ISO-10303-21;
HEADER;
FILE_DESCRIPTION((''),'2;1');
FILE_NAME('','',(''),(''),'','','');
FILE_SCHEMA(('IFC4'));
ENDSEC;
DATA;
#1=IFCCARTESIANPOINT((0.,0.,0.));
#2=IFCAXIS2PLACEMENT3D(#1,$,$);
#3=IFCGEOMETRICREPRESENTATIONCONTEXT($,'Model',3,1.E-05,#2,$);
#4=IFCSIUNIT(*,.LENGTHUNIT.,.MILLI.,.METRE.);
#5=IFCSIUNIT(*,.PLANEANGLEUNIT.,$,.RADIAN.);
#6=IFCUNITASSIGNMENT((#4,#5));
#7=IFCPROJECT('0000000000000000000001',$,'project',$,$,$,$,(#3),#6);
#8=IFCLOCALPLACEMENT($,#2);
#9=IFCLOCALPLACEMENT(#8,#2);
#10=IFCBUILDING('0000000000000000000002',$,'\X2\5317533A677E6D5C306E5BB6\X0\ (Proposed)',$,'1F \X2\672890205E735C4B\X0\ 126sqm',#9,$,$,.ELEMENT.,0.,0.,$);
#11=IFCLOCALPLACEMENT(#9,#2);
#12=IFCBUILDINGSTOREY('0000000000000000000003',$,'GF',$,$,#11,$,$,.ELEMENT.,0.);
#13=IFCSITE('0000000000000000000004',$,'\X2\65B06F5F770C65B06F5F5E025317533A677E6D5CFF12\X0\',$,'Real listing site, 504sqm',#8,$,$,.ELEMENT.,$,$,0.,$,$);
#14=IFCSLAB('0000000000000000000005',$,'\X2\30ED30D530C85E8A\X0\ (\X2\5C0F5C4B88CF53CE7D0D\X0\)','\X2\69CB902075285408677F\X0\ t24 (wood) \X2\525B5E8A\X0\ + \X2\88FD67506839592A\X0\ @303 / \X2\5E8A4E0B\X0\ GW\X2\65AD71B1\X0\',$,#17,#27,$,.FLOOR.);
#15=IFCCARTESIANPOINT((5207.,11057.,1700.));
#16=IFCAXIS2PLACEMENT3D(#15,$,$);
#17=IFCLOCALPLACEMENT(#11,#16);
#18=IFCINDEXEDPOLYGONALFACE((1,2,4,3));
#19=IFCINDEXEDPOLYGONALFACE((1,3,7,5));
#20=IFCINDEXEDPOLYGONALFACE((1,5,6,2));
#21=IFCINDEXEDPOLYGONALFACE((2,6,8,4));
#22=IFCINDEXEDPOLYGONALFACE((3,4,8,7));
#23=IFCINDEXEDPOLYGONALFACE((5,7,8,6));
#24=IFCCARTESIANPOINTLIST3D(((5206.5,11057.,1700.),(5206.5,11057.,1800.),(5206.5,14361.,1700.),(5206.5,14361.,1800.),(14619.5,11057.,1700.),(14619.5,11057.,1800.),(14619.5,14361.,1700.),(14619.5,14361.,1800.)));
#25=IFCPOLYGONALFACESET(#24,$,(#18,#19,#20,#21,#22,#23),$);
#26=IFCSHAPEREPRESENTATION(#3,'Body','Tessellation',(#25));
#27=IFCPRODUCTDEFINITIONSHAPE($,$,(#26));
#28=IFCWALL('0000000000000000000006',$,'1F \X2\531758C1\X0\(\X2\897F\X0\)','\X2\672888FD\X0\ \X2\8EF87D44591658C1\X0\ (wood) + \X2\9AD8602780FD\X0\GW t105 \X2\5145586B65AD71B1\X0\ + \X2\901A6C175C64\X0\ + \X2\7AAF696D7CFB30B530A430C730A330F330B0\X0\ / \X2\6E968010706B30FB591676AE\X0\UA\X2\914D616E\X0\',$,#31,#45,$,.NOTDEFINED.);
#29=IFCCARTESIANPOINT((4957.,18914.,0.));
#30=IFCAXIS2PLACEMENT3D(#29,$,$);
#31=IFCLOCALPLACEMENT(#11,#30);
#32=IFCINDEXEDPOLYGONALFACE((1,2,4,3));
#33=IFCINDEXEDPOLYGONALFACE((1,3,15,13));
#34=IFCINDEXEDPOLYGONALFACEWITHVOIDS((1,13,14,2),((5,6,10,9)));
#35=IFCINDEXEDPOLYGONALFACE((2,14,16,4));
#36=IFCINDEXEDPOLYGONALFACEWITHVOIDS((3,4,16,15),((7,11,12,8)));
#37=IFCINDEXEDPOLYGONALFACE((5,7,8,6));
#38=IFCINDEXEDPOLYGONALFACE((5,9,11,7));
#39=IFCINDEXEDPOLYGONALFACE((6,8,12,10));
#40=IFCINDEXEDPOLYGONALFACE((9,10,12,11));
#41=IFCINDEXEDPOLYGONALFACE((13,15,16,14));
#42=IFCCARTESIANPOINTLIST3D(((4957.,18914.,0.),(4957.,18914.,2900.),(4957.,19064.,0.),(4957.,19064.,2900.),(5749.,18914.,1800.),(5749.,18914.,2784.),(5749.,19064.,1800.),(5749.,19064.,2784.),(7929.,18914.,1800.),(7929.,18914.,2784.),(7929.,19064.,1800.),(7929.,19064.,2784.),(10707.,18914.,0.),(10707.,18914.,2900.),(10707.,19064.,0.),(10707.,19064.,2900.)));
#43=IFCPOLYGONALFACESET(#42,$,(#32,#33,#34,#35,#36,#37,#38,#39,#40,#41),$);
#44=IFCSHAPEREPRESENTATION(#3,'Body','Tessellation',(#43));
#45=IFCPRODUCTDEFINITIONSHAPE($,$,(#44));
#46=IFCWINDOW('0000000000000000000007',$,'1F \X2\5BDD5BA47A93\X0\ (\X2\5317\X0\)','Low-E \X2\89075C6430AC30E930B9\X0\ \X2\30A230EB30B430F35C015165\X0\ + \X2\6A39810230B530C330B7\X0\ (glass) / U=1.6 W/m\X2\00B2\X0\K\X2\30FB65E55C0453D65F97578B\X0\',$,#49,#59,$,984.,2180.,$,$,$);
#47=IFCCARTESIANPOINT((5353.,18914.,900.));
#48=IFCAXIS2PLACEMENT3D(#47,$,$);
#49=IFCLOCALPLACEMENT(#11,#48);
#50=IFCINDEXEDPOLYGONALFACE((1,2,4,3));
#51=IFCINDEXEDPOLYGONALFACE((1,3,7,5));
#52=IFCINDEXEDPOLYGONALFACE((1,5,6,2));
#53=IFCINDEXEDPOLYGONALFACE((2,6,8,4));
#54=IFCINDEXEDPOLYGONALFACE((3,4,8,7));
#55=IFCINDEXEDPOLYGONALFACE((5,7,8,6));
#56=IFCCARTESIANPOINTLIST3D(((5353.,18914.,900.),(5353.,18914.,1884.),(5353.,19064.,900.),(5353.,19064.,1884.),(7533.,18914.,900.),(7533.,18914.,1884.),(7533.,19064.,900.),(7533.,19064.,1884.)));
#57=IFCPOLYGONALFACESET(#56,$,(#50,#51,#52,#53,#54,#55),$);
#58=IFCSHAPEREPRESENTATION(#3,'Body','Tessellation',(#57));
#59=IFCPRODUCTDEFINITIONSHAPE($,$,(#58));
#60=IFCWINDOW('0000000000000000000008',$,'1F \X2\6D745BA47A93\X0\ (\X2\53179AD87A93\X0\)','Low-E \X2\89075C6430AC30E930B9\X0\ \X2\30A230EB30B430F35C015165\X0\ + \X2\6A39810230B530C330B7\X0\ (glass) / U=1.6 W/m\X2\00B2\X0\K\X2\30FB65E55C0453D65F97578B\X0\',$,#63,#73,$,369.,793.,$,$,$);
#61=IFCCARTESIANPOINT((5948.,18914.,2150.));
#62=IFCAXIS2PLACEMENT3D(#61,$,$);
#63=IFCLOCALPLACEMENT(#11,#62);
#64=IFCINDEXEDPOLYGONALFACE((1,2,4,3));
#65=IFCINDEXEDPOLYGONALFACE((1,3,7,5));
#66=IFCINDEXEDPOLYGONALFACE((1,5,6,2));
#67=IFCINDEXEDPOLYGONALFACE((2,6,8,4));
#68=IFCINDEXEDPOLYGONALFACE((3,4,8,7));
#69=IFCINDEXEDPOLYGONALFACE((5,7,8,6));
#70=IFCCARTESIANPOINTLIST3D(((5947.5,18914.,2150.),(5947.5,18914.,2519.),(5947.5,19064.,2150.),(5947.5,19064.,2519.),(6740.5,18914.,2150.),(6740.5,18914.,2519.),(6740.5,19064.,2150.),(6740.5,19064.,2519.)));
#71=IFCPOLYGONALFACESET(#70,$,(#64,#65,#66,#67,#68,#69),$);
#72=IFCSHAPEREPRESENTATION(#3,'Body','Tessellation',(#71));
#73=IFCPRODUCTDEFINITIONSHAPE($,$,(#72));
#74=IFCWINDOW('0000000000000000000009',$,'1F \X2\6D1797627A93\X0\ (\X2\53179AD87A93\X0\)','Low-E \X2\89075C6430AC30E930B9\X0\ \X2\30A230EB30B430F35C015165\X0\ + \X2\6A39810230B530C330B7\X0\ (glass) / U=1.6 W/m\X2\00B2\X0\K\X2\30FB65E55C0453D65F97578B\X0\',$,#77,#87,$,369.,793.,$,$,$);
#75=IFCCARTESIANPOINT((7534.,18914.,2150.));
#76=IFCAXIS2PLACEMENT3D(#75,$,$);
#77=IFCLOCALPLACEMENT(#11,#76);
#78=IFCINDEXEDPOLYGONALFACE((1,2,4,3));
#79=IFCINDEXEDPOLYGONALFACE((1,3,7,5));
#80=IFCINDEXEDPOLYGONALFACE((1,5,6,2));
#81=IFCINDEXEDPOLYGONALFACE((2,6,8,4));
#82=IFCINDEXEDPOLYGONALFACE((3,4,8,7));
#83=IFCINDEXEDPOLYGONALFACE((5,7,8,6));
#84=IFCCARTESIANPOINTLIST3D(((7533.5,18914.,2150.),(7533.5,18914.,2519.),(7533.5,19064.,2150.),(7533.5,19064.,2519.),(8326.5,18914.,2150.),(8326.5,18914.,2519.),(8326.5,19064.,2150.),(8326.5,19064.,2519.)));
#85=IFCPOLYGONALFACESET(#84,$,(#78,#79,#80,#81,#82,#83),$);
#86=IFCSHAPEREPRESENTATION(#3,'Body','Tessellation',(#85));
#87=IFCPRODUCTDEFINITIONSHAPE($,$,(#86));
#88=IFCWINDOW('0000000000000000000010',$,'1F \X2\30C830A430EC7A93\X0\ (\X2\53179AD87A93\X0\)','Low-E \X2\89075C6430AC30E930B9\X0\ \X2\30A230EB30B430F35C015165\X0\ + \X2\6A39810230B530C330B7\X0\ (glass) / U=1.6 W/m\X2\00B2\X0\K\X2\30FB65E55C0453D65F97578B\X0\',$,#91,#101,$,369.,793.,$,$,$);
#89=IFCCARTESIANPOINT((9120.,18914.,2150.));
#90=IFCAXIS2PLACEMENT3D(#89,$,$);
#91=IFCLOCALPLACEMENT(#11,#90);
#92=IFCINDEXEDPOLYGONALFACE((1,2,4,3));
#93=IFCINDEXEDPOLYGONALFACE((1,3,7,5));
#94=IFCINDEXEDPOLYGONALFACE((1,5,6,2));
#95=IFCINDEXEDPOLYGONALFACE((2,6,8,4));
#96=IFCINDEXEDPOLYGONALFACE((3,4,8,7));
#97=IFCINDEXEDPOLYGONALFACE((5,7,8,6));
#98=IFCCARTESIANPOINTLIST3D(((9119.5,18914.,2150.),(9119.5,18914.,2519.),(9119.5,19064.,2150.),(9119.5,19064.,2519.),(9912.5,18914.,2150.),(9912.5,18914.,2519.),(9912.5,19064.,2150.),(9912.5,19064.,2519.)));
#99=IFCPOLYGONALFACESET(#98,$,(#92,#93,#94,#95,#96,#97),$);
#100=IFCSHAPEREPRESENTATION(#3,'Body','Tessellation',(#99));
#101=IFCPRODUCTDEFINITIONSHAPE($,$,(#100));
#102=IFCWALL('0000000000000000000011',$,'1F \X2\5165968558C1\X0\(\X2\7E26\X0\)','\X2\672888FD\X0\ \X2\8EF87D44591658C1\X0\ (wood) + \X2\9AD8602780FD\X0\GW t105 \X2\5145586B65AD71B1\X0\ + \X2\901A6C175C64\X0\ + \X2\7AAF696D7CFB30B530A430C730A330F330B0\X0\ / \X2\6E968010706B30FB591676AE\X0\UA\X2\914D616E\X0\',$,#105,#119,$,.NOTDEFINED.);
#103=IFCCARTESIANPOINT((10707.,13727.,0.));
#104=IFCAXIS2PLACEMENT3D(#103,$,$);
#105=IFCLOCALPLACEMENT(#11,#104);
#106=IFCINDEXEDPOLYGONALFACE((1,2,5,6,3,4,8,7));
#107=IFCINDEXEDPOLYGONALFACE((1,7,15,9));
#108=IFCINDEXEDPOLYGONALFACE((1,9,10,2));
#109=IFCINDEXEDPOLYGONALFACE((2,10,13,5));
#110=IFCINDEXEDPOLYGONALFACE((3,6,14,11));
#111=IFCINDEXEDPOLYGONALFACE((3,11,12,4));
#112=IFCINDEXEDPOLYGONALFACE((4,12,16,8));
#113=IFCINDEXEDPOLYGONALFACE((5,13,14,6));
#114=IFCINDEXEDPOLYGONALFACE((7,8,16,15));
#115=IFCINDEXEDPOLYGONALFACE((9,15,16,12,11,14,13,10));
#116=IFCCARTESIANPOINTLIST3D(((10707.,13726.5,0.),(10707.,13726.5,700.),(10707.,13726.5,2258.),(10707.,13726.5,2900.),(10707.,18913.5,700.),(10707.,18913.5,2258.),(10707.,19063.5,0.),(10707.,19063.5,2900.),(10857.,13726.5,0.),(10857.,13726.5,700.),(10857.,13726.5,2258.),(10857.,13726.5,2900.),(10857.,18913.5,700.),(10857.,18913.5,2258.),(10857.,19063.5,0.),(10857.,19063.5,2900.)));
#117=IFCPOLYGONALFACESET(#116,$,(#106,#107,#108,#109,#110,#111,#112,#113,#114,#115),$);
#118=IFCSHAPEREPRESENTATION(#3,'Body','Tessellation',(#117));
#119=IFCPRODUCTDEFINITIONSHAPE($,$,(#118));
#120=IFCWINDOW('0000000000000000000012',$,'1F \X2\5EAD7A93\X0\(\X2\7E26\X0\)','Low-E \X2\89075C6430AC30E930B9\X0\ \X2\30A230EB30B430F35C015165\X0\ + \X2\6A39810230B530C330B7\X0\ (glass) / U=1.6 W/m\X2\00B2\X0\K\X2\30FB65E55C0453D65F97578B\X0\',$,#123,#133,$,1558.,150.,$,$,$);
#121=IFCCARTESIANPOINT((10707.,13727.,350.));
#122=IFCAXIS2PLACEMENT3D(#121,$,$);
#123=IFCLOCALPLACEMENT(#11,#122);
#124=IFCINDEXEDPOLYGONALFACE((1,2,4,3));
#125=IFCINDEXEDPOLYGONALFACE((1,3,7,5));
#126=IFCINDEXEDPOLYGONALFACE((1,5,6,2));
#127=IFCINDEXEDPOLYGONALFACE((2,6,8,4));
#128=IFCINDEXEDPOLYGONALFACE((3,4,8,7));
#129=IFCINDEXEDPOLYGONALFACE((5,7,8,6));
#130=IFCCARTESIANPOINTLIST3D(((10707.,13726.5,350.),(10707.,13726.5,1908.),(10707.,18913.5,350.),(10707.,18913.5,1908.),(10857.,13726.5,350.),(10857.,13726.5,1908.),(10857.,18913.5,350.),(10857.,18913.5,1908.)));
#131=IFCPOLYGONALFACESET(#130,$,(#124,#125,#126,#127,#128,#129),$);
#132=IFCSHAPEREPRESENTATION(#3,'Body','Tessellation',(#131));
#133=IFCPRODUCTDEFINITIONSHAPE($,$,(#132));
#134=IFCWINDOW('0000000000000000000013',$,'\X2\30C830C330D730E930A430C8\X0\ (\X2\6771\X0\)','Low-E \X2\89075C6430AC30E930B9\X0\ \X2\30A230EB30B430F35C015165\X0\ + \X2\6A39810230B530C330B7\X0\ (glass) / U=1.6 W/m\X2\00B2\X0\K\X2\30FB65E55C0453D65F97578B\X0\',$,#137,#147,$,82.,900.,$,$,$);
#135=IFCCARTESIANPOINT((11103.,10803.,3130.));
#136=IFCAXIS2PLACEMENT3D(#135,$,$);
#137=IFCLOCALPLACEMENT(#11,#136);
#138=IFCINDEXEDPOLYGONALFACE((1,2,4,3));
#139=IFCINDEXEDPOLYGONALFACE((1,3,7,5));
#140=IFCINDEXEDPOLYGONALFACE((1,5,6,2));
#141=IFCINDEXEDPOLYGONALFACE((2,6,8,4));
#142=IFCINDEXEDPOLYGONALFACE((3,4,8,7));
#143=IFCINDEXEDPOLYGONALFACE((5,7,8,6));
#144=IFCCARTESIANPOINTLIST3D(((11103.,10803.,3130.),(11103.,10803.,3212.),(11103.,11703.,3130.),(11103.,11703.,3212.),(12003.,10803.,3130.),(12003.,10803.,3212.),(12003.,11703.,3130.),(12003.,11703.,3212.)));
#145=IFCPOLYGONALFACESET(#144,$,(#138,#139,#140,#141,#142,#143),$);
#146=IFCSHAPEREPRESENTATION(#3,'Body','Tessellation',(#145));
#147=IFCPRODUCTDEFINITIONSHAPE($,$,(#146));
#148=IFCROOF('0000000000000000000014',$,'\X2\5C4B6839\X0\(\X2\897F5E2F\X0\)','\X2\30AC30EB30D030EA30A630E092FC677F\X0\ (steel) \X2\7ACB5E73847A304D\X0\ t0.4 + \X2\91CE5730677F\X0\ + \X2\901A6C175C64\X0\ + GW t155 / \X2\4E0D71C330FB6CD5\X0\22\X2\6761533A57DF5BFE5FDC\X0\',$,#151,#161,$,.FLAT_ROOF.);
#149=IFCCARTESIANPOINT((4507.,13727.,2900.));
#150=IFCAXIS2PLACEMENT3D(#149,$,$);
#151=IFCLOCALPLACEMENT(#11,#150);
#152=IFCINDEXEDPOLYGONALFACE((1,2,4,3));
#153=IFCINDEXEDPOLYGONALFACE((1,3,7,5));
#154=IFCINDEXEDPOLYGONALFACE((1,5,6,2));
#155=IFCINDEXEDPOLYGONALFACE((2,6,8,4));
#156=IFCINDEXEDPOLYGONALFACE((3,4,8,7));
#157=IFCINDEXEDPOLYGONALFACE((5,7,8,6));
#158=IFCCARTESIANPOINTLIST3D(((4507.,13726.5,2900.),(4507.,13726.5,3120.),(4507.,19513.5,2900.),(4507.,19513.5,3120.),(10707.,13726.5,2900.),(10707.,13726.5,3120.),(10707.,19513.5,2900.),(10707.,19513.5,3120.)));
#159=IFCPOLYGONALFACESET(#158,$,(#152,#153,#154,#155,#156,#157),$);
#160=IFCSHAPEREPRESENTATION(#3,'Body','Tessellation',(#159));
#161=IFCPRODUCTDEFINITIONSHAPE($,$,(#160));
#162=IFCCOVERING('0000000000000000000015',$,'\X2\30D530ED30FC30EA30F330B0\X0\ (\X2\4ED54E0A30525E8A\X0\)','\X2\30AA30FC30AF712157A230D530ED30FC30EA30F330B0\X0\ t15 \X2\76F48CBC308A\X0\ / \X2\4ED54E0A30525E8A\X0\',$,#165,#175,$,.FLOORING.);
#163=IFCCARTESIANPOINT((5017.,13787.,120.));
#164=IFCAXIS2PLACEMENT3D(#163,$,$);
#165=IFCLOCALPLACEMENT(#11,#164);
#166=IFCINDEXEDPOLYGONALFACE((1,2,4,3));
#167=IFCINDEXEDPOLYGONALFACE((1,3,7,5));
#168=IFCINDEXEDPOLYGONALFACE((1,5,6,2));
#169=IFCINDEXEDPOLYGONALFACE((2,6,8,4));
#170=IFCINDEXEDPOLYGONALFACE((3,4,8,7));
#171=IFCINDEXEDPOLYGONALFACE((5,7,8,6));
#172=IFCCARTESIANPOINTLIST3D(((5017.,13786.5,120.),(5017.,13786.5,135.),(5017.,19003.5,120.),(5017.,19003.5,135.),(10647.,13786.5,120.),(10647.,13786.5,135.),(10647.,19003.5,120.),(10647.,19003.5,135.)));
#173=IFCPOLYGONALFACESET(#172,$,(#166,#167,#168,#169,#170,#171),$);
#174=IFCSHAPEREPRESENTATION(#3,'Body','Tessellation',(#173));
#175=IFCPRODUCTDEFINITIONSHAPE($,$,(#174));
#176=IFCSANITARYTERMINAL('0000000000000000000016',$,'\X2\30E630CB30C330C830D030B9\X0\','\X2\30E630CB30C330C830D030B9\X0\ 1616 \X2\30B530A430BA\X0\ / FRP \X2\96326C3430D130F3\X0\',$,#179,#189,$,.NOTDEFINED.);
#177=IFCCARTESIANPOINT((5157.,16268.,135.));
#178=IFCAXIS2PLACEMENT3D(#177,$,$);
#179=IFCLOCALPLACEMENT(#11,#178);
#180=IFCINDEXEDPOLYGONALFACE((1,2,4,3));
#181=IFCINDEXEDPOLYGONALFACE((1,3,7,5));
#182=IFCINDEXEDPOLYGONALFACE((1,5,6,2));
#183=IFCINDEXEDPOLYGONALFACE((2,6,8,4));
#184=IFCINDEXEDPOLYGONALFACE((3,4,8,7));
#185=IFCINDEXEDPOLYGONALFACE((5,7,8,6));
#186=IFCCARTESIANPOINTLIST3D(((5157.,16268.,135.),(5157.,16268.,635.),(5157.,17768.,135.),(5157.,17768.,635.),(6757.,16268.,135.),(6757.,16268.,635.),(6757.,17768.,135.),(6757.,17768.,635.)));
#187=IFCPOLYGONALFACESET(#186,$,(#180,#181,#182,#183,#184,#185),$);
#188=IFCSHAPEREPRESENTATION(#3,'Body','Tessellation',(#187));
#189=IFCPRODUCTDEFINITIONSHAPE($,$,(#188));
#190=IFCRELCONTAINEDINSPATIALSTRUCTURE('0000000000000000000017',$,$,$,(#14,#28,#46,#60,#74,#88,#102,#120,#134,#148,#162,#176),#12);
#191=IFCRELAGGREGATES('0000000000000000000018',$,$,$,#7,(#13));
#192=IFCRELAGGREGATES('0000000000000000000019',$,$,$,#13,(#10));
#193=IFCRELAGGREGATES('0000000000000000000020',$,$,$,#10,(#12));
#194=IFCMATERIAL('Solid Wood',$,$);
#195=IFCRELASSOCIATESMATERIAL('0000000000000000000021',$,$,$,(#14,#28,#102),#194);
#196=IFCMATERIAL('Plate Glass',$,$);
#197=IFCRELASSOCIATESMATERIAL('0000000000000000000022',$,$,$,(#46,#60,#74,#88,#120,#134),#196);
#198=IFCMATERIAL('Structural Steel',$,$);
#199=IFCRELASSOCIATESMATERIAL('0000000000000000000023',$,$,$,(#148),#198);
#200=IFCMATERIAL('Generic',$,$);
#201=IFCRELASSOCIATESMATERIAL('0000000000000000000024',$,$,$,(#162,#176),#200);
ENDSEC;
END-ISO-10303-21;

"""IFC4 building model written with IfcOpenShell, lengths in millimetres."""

from ifc_helpers import new_model, si_unit, frame, frame_2d, origin, place, context, project, spatial, rectangle, extrude, material, element, fill, save


model = new_model("IFC4")

# Units and contexts
model_context = context("Model", 3, precision=1e-05, world=origin())
ifc_project = project(units=[si_unit("LENGTHUNIT", "METRE", prefix="MILLI"), si_unit("PLANEANGLEUNIT", "RADIAN")], contexts=[model_context])

# Site, building, storey
site_placement = place(None, origin())
site = spatial("IfcSite", under=ifc_project, at=site_placement, Name="新潟県新潟市北区松浜２", ObjectType="Real listing site, 504sqm", CompositionType="ELEMENT", RefElevation=0.0)
building_placement = place(site_placement, origin())
building = spatial("IfcBuilding", under=site, at=building_placement, Name="北区松浜の家 (Proposed)", ObjectType="1F 木造平屋 126sqm", CompositionType="ELEMENT", ElevationOfRefHeight=0.0, ElevationOfTerrain=0.0)
storey_placement = place(building_placement, origin())
storey = spatial("IfcBuildingStorey", under=building, at=storey_placement, Name="GF", CompositionType="ELEMENT", Elevation=0.0)

# Slab
ifc_material_1 = material(Name="Solid Wood")
slab_1_placement = place(storey_placement, frame((5207.0, 11057.0, 1700.0)))
element("IfcSlab", 1, at=slab_1_placement, inside=storey, material=ifc_material_1, Name="ロフト床 (小屋裏収納)", Description="構造用合板 t24 (wood) 剛床 + 製材根太 @303 / 床下 GW断熱", PredefinedType="FLOOR", context=model_context, shape_type="SweptSolid", body=[
    extrude(rectangle(XDim=9413.0, YDim=3304.0, at=frame_2d((4706.0, 1652.0))), frame((5207.0, 11057.0, 1700.0)), (0.0, 0.0, 1.0), 100.0),
])

# Wall, openings, windows
wall_1_placement = place(storey_placement, frame((4957.0, 18914.0, 0.0)))
wall_1 = element("IfcWall", 2, at=wall_1_placement, inside=storey, material=ifc_material_1, Name="1F 北壁(西)", Description="木製 軸組外壁 (wood) + 高性能GW t105 充填断熱 + 通気層 + 窯業系サイディング / 準耐火・外皮UA配慮", PredefinedType="NOTDEFINED", context=model_context, shape_type="SweptSolid", body=[
    extrude(rectangle(XDim=5750.0, YDim=150.0, at=frame_2d((2875.0, 75.0))), frame((4957.0, 18914.0, 0.0)), (0.0, 0.0, 1.0), 2900.0),
])
opening_1_placement = place(storey_placement, frame((5353.0, 18914.0, 900.0)))
opening_1 = element("IfcOpeningElement", 3, at=opening_1_placement, cuts=wall_1, PredefinedType="NOTDEFINED", context=model_context, shape_type="SweptSolid", body=[
    extrude(rectangle(XDim=2180.0, YDim=150.0, at=frame_2d((1090.0, 75.0))), frame((5353.0, 18914.0, 900.0)), (0.0, 0.0, 1.0), 984.0),
])
opening_2_placement = place(storey_placement, frame((5948.0, 18914.0, 2150.0)))
opening_2 = element("IfcOpeningElement", 4, at=opening_2_placement, cuts=wall_1, PredefinedType="NOTDEFINED", context=model_context, shape_type="SweptSolid", body=[
    extrude(rectangle(XDim=793.0, YDim=150.0, at=frame_2d((396.0, 75.0))), frame((5948.0, 18914.0, 2150.0)), (0.0, 0.0, 1.0), 369.0),
])
opening_3_placement = place(storey_placement, frame((7534.0, 18914.0, 2150.0)))
opening_3 = element("IfcOpeningElement", 5, at=opening_3_placement, cuts=wall_1, PredefinedType="NOTDEFINED", context=model_context, shape_type="SweptSolid", body=[
    extrude(rectangle(XDim=793.0, YDim=150.0, at=frame_2d((396.0, 75.0))), frame((7534.0, 18914.0, 2150.0)), (0.0, 0.0, 1.0), 369.0),
])
opening_4_placement = place(storey_placement, frame((9120.0, 18914.0, 2150.0)))
opening_4 = element("IfcOpeningElement", 6, at=opening_4_placement, cuts=wall_1, PredefinedType="NOTDEFINED", context=model_context, shape_type="SweptSolid", body=[
    extrude(rectangle(XDim=793.0, YDim=150.0, at=frame_2d((396.0, 75.0))), frame((9120.0, 18914.0, 2150.0)), (0.0, 0.0, 1.0), 369.0),
])
ifc_material_2 = material(Name="Plate Glass")
window_1_placement = place(storey_placement, frame((5353.0, 18914.0, 900.0)))
window_1 = element("IfcWindow", 7, at=window_1_placement, inside=storey, material=ifc_material_2, Name="1F 寝室窓 (北)", Description="Low-E 複層ガラス アルゴン封入 + 樹脂サッシ (glass) / U=1.6 W/m²K・日射取得型", OverallHeight=984.0, OverallWidth=2180.0, context=model_context, shape_type="SweptSolid", body=[
    extrude(rectangle(XDim=2180.0, YDim=150.0, at=frame_2d((1090.0, 75.0))), frame((5353.0, 18914.0, 900.0)), (0.0, 0.0, 1.0), 984.0),
])
fill(opening_1, window_1)
window_2_placement = place(storey_placement, frame((5948.0, 18914.0, 2150.0)))
window_2 = element("IfcWindow", 8, at=window_2_placement, inside=storey, material=ifc_material_2, Name="1F 浴室窓 (北高窓)", Description="Low-E 複層ガラス アルゴン封入 + 樹脂サッシ (glass) / U=1.6 W/m²K・日射取得型", OverallHeight=369.0, OverallWidth=793.0, context=model_context, shape_type="SweptSolid", body=[
    extrude(rectangle(XDim=793.0, YDim=150.0, at=frame_2d((396.0, 75.0))), frame((5948.0, 18914.0, 2150.0)), (0.0, 0.0, 1.0), 369.0),
])
fill(opening_2, window_2)
window_3_placement = place(storey_placement, frame((7534.0, 18914.0, 2150.0)))
window_3 = element("IfcWindow", 9, at=window_3_placement, inside=storey, material=ifc_material_2, Name="1F 洗面窓 (北高窓)", Description="Low-E 複層ガラス アルゴン封入 + 樹脂サッシ (glass) / U=1.6 W/m²K・日射取得型", OverallHeight=369.0, OverallWidth=793.0, context=model_context, shape_type="SweptSolid", body=[
    extrude(rectangle(XDim=793.0, YDim=150.0, at=frame_2d((396.0, 75.0))), frame((7534.0, 18914.0, 2150.0)), (0.0, 0.0, 1.0), 369.0),
])
fill(opening_3, window_3)
window_4_placement = place(storey_placement, frame((9120.0, 18914.0, 2150.0)))
window_4 = element("IfcWindow", 10, at=window_4_placement, inside=storey, material=ifc_material_2, Name="1F トイレ窓 (北高窓)", Description="Low-E 複層ガラス アルゴン封入 + 樹脂サッシ (glass) / U=1.6 W/m²K・日射取得型", OverallHeight=369.0, OverallWidth=793.0, context=model_context, shape_type="SweptSolid", body=[
    extrude(rectangle(XDim=793.0, YDim=150.0, at=frame_2d((396.0, 75.0))), frame((9120.0, 18914.0, 2150.0)), (0.0, 0.0, 1.0), 369.0),
])
fill(opening_4, window_4)

# Wall, opening, window
wall_2_placement = place(storey_placement, frame((10707.0, 13727.0, 0.0)))
wall_2 = element("IfcWall", 11, at=wall_2_placement, inside=storey, material=ifc_material_1, Name="1F 入隅壁(縦)", Description="木製 軸組外壁 (wood) + 高性能GW t105 充填断熱 + 通気層 + 窯業系サイディング / 準耐火・外皮UA配慮", PredefinedType="NOTDEFINED", context=model_context, shape_type="SweptSolid", body=[
    extrude(rectangle(XDim=150.0, YDim=5337.0, at=frame_2d((75.0, 2668.0))), frame((10707.0, 13727.0, 0.0)), (0.0, 0.0, 1.0), 2900.0),
])
opening_5_placement = place(storey_placement, frame((10707.0, 13727.0, 350.0)))
opening_5 = element("IfcOpeningElement", 12, at=opening_5_placement, cuts=wall_2, PredefinedType="NOTDEFINED", context=model_context, shape_type="SweptSolid", body=[
    extrude(rectangle(XDim=150.0, YDim=5187.0, at=frame_2d((75.0, 2593.0))), frame((10707.0, 13727.0, 350.0)), (0.0, 0.0, 1.0), 1558.0),
])
window_5_placement = place(storey_placement, frame((10707.0, 13727.0, 350.0)))
window_5 = element("IfcWindow", 13, at=window_5_placement, inside=storey, material=ifc_material_2, Name="1F 庭窓(縦)", Description="Low-E 複層ガラス アルゴン封入 + 樹脂サッシ (glass) / U=1.6 W/m²K・日射取得型", OverallHeight=1558.0, OverallWidth=150.0, context=model_context, shape_type="SweptSolid", body=[
    extrude(rectangle(XDim=150.0, YDim=5187.0, at=frame_2d((75.0, 2593.0))), frame((10707.0, 13727.0, 350.0)), (0.0, 0.0, 1.0), 1558.0),
])
fill(opening_5, window_5)

# Window
window_6_placement = place(storey_placement, frame((11103.0, 10803.0, 3130.0)))
element("IfcWindow", 14, at=window_6_placement, inside=storey, material=ifc_material_2, Name="トップライト (東)", Description="Low-E 複層ガラス アルゴン封入 + 樹脂サッシ (glass) / U=1.6 W/m²K・日射取得型", OverallHeight=82.0, OverallWidth=900.0, context=model_context, shape_type="SweptSolid", body=[
    extrude(rectangle(XDim=900.0, YDim=900.0, at=frame_2d((450.0, 450.0))), frame((11103.0, 10803.0, 3130.0)), (0.0, 0.0, 1.0), 82.0),
])

# Roof
ifc_material_3 = material(Name="Structural Steel")
roof_placement = place(storey_placement, frame((4507.0, 13727.0, 2900.0)))
element("IfcRoof", 15, at=roof_placement, inside=storey, material=ifc_material_3, Name="屋根(西帯)", Description="ガルバリウム鋼板 (steel) 立平葺き t0.4 + 野地板 + 通気層 + GW t155 / 不燃・法22条区域対応", PredefinedType="FLAT_ROOF", context=model_context, shape_type="SweptSolid", body=[
    extrude(rectangle(XDim=6200.0, YDim=5787.0, at=frame_2d((3100.0, 2893.0))), frame((4507.0, 13727.0, 2900.0)), (0.0, 0.0, 1.0), 220.0),
])

# Covering
ifc_material_4 = material(Name="Generic")
covering_placement = place(storey_placement, frame((5017.0, 13787.0, 120.0)))
element("IfcCovering", 16, at=covering_placement, inside=storey, material=ifc_material_4, Name="フローリング (仕上げ床)", Description="オーク無垢フローリング t15 直貼り / 仕上げ床", PredefinedType="FLOORING", context=model_context, shape_type="SweptSolid", body=[
    extrude(rectangle(XDim=5630.0, YDim=5217.0, at=frame_2d((2815.0, 2608.0))), frame((5017.0, 13787.0, 120.0)), (0.0, 0.0, 1.0), 15.0),
])

# Sanitary terminal
sanitary_terminal_1_placement = place(storey_placement, frame((5157.0, 16268.0, 135.0)))
element("IfcSanitaryTerminal", 17, at=sanitary_terminal_1_placement, inside=storey, material=ifc_material_4, Name="ユニットバス", Description="ユニットバス 1616 サイズ / FRP 防水パン", PredefinedType="NOTDEFINED", context=model_context, shape_type="SweptSolid", body=[
    extrude(rectangle(XDim=1600.0, YDim=1500.0, at=frame_2d((800.0, 750.0))), frame((5157.0, 16268.0, 135.0)), (0.0, 0.0, 1.0), 500.0),
])

save(model, "model.ifc")
